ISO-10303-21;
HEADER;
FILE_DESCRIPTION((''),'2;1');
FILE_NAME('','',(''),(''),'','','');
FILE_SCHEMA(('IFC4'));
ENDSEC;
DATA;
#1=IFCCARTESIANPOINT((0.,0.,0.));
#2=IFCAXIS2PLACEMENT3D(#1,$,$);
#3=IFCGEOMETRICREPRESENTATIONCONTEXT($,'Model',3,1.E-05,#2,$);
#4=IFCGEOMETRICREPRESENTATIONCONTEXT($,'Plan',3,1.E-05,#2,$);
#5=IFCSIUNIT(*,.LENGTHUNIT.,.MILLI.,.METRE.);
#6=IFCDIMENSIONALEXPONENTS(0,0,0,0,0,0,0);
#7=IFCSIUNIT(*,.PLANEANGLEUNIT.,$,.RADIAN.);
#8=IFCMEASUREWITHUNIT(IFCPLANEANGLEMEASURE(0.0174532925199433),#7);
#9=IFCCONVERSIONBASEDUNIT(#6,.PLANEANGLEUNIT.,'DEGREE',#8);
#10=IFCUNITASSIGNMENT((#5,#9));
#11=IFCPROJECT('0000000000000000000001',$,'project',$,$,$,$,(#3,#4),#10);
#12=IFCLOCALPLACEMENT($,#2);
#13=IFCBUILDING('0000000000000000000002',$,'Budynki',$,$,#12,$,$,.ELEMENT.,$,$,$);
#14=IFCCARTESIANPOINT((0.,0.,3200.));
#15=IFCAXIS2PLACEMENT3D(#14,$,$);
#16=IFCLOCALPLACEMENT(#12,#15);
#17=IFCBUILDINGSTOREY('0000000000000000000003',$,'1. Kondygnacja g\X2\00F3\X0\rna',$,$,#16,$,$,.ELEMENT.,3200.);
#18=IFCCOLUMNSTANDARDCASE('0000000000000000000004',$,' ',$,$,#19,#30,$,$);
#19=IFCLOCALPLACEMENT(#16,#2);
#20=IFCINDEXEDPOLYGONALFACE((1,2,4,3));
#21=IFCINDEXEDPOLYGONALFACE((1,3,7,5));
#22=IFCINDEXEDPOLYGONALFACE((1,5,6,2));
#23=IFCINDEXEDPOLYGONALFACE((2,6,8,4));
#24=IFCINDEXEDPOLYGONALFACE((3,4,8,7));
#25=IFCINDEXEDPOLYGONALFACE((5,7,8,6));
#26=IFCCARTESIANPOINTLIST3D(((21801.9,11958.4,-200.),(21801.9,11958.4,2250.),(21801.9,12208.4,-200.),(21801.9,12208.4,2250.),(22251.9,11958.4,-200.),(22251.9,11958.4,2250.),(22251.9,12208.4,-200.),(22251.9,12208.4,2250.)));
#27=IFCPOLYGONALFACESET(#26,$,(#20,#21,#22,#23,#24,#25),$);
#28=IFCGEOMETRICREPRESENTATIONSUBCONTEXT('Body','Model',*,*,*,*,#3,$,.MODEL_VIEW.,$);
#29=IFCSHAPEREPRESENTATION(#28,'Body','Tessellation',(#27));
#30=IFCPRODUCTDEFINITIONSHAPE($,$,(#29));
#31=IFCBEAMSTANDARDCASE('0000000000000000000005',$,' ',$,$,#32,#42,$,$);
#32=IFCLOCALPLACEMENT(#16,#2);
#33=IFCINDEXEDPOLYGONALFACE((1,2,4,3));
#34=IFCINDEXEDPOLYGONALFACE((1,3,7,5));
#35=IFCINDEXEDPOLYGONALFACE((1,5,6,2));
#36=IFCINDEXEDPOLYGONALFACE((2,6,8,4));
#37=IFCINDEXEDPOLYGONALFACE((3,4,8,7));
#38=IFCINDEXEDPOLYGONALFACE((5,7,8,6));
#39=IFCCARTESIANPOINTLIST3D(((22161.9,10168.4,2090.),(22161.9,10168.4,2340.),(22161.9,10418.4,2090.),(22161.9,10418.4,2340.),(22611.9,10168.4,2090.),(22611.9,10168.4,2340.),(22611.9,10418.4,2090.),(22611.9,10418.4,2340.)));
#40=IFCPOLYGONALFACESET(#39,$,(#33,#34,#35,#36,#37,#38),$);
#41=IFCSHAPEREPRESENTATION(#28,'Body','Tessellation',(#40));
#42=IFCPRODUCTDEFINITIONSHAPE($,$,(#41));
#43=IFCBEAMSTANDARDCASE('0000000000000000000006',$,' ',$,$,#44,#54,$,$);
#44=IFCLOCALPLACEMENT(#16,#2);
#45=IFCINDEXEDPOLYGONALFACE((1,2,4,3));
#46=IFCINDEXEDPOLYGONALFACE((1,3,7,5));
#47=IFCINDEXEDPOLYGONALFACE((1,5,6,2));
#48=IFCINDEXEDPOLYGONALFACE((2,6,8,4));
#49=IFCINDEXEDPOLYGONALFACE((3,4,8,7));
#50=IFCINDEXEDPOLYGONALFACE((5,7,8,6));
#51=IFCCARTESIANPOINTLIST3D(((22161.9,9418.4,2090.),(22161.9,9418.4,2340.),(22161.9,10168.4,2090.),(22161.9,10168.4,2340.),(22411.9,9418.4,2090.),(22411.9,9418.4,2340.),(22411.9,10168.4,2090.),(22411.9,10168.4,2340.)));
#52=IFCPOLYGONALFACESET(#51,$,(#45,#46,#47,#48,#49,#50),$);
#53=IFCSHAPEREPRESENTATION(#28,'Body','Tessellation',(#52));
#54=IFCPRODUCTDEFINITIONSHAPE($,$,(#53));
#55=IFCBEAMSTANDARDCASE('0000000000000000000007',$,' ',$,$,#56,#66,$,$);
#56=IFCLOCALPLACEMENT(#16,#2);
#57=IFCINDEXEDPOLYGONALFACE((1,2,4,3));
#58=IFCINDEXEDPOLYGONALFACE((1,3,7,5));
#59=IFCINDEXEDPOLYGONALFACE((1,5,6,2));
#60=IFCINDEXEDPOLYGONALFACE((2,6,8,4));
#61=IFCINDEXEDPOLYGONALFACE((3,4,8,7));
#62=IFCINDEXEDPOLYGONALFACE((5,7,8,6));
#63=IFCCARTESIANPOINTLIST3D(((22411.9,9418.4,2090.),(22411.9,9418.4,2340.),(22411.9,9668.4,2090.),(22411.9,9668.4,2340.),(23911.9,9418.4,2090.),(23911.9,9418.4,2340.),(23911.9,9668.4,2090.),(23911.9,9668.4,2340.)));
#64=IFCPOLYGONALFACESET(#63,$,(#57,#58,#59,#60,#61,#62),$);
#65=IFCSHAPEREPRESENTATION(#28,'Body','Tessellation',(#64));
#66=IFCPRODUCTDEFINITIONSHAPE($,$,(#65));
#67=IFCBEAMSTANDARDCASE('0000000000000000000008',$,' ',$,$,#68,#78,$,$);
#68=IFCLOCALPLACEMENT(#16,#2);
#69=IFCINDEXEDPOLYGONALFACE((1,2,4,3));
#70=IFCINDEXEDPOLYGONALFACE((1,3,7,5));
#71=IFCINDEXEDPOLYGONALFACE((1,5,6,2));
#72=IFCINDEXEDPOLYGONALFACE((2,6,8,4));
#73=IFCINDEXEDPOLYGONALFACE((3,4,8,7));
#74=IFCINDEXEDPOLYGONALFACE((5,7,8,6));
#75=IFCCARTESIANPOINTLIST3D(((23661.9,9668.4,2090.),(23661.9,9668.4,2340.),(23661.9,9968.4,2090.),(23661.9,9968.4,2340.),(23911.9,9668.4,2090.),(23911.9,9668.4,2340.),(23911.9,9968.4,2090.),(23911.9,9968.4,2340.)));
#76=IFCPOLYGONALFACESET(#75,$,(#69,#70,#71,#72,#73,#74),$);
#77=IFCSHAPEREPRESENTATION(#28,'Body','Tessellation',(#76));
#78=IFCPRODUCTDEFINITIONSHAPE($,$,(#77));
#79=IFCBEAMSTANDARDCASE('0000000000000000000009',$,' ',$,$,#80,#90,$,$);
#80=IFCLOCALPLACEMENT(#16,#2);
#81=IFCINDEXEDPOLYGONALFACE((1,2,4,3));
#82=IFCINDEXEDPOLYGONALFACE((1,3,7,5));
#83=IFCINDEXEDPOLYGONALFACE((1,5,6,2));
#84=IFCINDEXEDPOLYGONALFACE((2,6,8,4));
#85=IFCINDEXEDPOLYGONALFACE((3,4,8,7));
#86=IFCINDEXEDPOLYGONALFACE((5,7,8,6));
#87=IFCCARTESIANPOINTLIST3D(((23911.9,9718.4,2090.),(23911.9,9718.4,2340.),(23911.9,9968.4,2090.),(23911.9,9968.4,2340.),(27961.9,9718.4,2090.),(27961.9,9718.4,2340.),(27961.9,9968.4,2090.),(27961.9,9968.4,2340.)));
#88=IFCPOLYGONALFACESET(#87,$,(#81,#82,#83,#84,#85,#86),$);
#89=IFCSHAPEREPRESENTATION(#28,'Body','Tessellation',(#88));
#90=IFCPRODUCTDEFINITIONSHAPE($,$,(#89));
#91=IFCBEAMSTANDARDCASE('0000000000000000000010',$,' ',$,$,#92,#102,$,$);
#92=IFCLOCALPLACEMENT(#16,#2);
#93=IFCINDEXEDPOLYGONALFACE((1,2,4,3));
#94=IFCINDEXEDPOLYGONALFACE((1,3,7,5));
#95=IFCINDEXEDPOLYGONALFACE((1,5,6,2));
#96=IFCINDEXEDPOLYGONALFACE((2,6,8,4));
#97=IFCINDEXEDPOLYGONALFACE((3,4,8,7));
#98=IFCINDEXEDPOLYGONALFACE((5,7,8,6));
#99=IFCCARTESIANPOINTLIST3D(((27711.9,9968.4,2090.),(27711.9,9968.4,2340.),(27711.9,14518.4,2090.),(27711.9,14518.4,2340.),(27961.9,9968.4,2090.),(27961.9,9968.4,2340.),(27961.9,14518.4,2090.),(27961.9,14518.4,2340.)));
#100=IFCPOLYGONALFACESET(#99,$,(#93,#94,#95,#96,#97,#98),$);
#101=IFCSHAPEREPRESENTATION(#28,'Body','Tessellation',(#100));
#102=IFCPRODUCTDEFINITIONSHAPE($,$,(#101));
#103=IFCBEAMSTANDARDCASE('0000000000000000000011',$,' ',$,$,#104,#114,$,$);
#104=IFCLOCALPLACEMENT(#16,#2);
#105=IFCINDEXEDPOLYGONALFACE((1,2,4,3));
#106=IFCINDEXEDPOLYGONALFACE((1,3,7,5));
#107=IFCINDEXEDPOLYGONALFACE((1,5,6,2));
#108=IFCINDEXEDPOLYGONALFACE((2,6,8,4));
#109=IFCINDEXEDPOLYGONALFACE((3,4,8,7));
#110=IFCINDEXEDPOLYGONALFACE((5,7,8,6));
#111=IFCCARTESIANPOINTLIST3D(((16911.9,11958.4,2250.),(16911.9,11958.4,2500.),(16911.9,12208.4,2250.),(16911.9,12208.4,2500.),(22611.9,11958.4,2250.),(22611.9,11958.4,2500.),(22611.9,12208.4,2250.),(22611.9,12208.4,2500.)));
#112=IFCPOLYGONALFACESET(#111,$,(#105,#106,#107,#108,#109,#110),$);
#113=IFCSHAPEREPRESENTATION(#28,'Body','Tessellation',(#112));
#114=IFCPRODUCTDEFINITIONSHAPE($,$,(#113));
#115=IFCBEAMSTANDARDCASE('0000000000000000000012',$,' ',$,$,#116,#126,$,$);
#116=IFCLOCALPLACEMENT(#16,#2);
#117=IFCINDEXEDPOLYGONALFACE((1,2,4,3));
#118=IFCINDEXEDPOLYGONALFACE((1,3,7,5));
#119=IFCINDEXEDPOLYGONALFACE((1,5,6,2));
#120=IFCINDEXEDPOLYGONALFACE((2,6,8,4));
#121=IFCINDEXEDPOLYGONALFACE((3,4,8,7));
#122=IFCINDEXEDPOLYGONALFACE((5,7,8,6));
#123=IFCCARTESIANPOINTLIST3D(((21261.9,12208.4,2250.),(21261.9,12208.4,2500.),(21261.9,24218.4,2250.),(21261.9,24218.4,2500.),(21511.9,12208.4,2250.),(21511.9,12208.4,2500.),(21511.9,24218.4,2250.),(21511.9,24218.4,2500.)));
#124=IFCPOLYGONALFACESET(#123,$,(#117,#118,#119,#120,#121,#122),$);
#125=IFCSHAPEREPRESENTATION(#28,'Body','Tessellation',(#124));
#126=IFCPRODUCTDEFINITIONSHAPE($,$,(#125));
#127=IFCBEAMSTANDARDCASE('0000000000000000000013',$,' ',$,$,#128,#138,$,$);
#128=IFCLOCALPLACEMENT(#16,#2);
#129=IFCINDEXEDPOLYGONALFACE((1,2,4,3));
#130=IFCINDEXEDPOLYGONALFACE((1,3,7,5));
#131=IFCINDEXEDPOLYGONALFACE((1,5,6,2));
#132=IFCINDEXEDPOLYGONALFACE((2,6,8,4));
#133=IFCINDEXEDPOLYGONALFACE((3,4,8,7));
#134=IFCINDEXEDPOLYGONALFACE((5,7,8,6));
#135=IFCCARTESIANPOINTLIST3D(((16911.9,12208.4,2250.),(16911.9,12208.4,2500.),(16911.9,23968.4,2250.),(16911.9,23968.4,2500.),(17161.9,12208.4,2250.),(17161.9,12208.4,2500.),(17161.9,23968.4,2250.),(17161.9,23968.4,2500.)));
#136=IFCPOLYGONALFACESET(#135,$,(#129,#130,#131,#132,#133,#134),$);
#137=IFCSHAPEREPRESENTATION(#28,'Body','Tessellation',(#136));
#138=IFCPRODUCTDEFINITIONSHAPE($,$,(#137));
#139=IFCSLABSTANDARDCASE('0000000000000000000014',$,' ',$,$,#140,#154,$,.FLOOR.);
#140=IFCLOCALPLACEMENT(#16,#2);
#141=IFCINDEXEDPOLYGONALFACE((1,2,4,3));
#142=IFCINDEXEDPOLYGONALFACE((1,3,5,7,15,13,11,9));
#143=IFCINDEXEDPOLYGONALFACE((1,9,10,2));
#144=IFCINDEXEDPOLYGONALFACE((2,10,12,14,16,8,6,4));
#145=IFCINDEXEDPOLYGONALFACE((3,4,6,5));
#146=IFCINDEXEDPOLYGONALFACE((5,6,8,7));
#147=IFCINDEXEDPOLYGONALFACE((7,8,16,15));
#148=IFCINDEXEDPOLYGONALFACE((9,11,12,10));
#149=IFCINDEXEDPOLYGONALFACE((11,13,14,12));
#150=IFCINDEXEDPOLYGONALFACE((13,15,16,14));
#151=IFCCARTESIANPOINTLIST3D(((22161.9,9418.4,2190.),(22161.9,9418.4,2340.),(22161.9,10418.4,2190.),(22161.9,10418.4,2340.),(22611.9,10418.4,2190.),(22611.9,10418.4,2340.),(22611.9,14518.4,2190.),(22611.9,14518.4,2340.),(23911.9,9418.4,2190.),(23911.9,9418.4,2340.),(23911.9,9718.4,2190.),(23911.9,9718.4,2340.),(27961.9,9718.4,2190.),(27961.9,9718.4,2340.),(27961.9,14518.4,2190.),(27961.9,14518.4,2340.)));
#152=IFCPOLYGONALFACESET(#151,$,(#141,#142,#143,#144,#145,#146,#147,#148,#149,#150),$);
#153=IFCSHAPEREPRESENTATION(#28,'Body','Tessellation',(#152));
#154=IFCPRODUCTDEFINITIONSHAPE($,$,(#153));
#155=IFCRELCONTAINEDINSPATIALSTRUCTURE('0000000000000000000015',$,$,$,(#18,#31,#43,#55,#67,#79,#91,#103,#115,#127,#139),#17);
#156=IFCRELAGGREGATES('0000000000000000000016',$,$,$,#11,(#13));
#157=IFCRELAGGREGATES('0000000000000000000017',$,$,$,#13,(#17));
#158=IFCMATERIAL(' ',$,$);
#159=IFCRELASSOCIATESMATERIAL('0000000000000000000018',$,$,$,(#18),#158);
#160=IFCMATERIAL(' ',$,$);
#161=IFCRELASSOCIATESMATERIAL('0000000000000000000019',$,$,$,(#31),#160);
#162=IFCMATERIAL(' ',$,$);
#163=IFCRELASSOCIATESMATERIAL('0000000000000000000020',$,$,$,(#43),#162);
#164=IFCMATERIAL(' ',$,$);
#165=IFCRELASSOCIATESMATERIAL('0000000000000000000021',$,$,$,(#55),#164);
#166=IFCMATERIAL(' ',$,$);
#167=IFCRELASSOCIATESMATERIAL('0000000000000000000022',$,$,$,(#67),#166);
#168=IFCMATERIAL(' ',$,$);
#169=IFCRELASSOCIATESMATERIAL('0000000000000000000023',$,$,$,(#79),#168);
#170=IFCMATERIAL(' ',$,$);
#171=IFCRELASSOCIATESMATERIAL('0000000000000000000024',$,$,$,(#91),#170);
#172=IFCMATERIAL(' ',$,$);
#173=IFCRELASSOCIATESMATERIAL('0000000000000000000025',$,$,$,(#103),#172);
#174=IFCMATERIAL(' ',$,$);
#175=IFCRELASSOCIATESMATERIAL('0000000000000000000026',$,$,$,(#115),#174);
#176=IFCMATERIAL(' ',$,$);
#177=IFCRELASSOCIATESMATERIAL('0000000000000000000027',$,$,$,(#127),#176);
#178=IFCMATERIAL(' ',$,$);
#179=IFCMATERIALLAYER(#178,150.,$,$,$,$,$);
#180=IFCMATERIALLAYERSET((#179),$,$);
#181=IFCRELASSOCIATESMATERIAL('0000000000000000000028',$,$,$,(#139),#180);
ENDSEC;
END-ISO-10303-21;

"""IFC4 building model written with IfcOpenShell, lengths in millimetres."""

from ifc_helpers import new_model, entity, si_unit, converted_unit, frame, frame_2d, origin, origin_with_axes, place, context, subcontext, project, spatial, polyline, rectangle, outline, extrude, material, layer, layer_set, layer_usage, material_profile, profile_set, profile_usage, element, save


model = new_model("IFC4")

# Units and contexts
model_context = context("Model", 3, precision=1e-05, world=origin())
plan_context = context("Plan", 3, precision=1e-05, world=origin())
body_context = subcontext(model_context, "Body", "Model", "MODEL_VIEW")
ifc_project = project(units=[si_unit("LENGTHUNIT", "METRE", prefix="MILLI"), converted_unit("PLANEANGLEUNIT", "DEGREE", entity("IfcPlaneAngleMeasure", 0.0174532925199433), si_unit("PLANEANGLEUNIT", "RADIAN"), dimensions=[0, 0, 0, 0, 0, 0, 0])], contexts=[model_context, plan_context])

# Building, storey
building_placement = place(None, origin())
building = spatial("IfcBuilding", under=ifc_project, at=building_placement, Name="Budynki", CompositionType="ELEMENT")
storey_placement = place(building_placement, frame((0.0, 0.0, 3200.0)))
storey = spatial("IfcBuildingStorey", under=building, at=storey_placement, Name="1. Kondygnacja górna", CompositionType="ELEMENT", Elevation=3200.0)

# Column
ifc_material_1 = material(Name=" ")
ifc_material_profile_1 = material_profile(ifc_material_1, rectangle(XDim=450.0, YDim=250.0, at=frame_2d((225.0, 125.0), x_axis=(1.0, 0.0))))
ifc_profile_set_1 = profile_set([ifc_material_profile_1])
ifc_profile_usage_1 = profile_usage(ifc_profile_set_1)
column_placement = place(storey_placement, frame((21801.9, 11958.4, -200.0)))
element("IfcColumnStandardCase", 1, at=column_placement, inside=storey, material=ifc_profile_usage_1, Name=" ", context=body_context, shape_type="SweptSolid", body=[
    extrude(rectangle(XDim=450.0, YDim=250.0, at=frame_2d((225.0, 125.0), x_axis=(1.0, 0.0))), frame((0.0, 0.0, 0.0), z_axis=(0.0, 0.0, 1.0), x_axis=(1.0, 0.0, 0.0)), (0.0, 0.0, 1.0), 2450.0),
])

# Beams
ifc_material_2 = material(Name=" ")
ifc_material_profile_2 = material_profile(ifc_material_2, rectangle(XDim=250.0, YDim=250.0, at=frame_2d((125.0, -125.0), x_axis=(0.0, 1.0))))
ifc_profile_set_2 = profile_set([ifc_material_profile_2])
ifc_profile_usage_2 = profile_usage(ifc_profile_set_2)
beam_1_placement = place(storey_placement, frame((22161.9, 10168.4, 2090.0), z_axis=(0.0, 0.0, 1.0), x_axis=(1.0, 0.0, 0.0)))
element("IfcBeamStandardCase", 2, at=beam_1_placement, inside=storey, material=ifc_profile_usage_2, Name=" ", context=body_context, shape_type="SweptSolid", body=[
    extrude(rectangle(XDim=250.0, YDim=250.0, at=frame_2d((125.0, -125.0), x_axis=(0.0, 1.0))), frame((0.0, 0.0, 0.0), z_axis=(1.0, 0.0, 0.0), x_axis=(0.0, 0.0, 1.0)), (0.0, 0.0, 1.0), 450.0),
])
ifc_material_3 = material(Name=" ")
ifc_material_profile_3 = material_profile(ifc_material_3, rectangle(XDim=250.0, YDim=250.0, at=frame_2d((125.0, -125.0), x_axis=(0.0, 1.0))))
ifc_profile_set_3 = profile_set([ifc_material_profile_3])
ifc_profile_usage_3 = profile_usage(ifc_profile_set_3)
beam_2_placement = place(storey_placement, frame((22161.9, 10168.4, 2090.0), z_axis=(0.0, 0.0, 1.0), x_axis=(0.0, -1.0, 0.0)))
element("IfcBeamStandardCase", 3, at=beam_2_placement, inside=storey, material=ifc_profile_usage_3, Name=" ", context=body_context, shape_type="SweptSolid", body=[
    extrude(rectangle(XDim=250.0, YDim=250.0, at=frame_2d((125.0, -125.0), x_axis=(0.0, 1.0))), frame((0.0, 0.0, 0.0), z_axis=(1.0, 0.0, 0.0), x_axis=(0.0, 0.0, 1.0)), (0.0, 0.0, 1.0), 750.0),
])
ifc_material_4 = material(Name=" ")
ifc_material_profile_4 = material_profile(ifc_material_4, rectangle(XDim=250.0, YDim=250.0, at=frame_2d((125.0, -125.0), x_axis=(0.0, 1.0))))
ifc_profile_set_4 = profile_set([ifc_material_profile_4])
ifc_profile_usage_4 = profile_usage(ifc_profile_set_4)
beam_3_placement = place(storey_placement, frame((22411.9, 9418.4, 2090.0)))
element("IfcBeamStandardCase", 4, at=beam_3_placement, inside=storey, material=ifc_profile_usage_4, Name=" ", context=body_context, shape_type="SweptSolid", body=[
    extrude(rectangle(XDim=250.0, YDim=250.0, at=frame_2d((125.0, -125.0), x_axis=(0.0, 1.0))), frame((0.0, 0.0, 0.0), z_axis=(1.0, 0.0, 0.0), x_axis=(0.0, 0.0, 1.0)), (0.0, 0.0, 1.0), 1500.0),
])
ifc_material_5 = material(Name=" ")
ifc_material_profile_5 = material_profile(ifc_material_5, rectangle(XDim=250.0, YDim=250.0, at=frame_2d((125.0, -125.0), x_axis=(0.0, 1.0))))
ifc_profile_set_5 = profile_set([ifc_material_profile_5])
ifc_profile_usage_5 = profile_usage(ifc_profile_set_5)
beam_4_placement = place(storey_placement, frame((23911.9, 9668.4, 2090.0), z_axis=(0.0, 0.0, 1.0), x_axis=(0.0, 1.0, 0.0)))
element("IfcBeamStandardCase", 5, at=beam_4_placement, inside=storey, material=ifc_profile_usage_5, Name=" ", context=body_context, shape_type="SweptSolid", body=[
    extrude(rectangle(XDim=250.0, YDim=250.0, at=frame_2d((125.0, -125.0), x_axis=(0.0, 1.0))), frame((0.0, 0.0, 0.0), z_axis=(1.0, 0.0, 0.0), x_axis=(0.0, 0.0, 1.0)), (0.0, 0.0, 1.0), 300.0),
])
ifc_material_6 = material(Name=" ")
ifc_material_profile_6 = material_profile(ifc_material_6, rectangle(XDim=250.0, YDim=250.0, at=frame_2d((125.0, -125.0), x_axis=(0.0, 1.0))))
ifc_profile_set_6 = profile_set([ifc_material_profile_6])
ifc_profile_usage_6 = profile_usage(ifc_profile_set_6)
beam_5_placement = place(storey_placement, frame((27961.9, 9968.4, 2090.0), z_axis=(0.0, 0.0, 1.0), x_axis=(-1.0, 0.0, 0.0)))
element("IfcBeamStandardCase", 6, at=beam_5_placement, inside=storey, material=ifc_profile_usage_6, Name=" ", context=body_context, shape_type="SweptSolid", body=[
    extrude(rectangle(XDim=250.0, YDim=250.0, at=frame_2d((125.0, -125.0), x_axis=(0.0, 1.0))), frame((0.0, 0.0, 0.0), z_axis=(1.0, 0.0, 0.0), x_axis=(0.0, 0.0, 1.0)), (0.0, 0.0, 1.0), 4050.0),
])
ifc_material_7 = material(Name=" ")
ifc_material_profile_7 = material_profile(ifc_material_7, rectangle(XDim=250.0, YDim=250.0, at=frame_2d((125.0, -125.0), x_axis=(0.0, 1.0))))
ifc_profile_set_7 = profile_set([ifc_material_profile_7])
ifc_profile_usage_7 = profile_usage(ifc_profile_set_7)
beam_6_placement = place(storey_placement, frame((27961.9, 9968.4, 2090.0), z_axis=(0.0, 0.0, 1.0), x_axis=(0.0, 1.0, 0.0)))
element("IfcBeamStandardCase", 7, at=beam_6_placement, inside=storey, material=ifc_profile_usage_7, Name=" ", context=body_context, shape_type="SweptSolid", body=[
    extrude(rectangle(XDim=250.0, YDim=250.0, at=frame_2d((125.0, -125.0), x_axis=(0.0, 1.0))), frame((0.0, 0.0, 0.0), z_axis=(1.0, 0.0, 0.0), x_axis=(0.0, 0.0, 1.0)), (0.0, 0.0, 1.0), 4550.0),
])
ifc_material_8 = material(Name=" ")
ifc_material_profile_8 = material_profile(ifc_material_8, rectangle(XDim=250.0, YDim=250.0, at=frame_2d((125.0, -125.0), x_axis=(0.0, 1.0))))
ifc_profile_set_8 = profile_set([ifc_material_profile_8])
ifc_profile_usage_8 = profile_usage(ifc_profile_set_8)
beam_7_placement = place(storey_placement, frame((22611.9, 12208.4, 2250.0), z_axis=(0.0, 0.0, 1.0), x_axis=(-1.0, 0.0, 0.0)))
element("IfcBeamStandardCase", 8, at=beam_7_placement, inside=storey, material=ifc_profile_usage_8, Name=" ", context=body_context, shape_type="SweptSolid", body=[
    extrude(rectangle(XDim=250.0, YDim=250.0, at=frame_2d((125.0, -125.0), x_axis=(0.0, 1.0))), frame((0.0, 0.0, 0.0), z_axis=(1.0, 0.0, 0.0), x_axis=(0.0, 0.0, 1.0)), (0.0, 0.0, 1.0), 5700.0),
])
ifc_material_9 = material(Name=" ")
ifc_material_profile_9 = material_profile(ifc_material_9, rectangle(XDim=250.0, YDim=250.0, at=frame_2d((125.0, -125.0), x_axis=(0.0, 1.0))))
ifc_profile_set_9 = profile_set([ifc_material_profile_9])
ifc_profile_usage_9 = profile_usage(ifc_profile_set_9)
beam_8_placement = place(storey_placement, frame((21511.9, 12208.4, 2250.0), z_axis=(0.0, 0.0, 1.0), x_axis=(0.0, 1.0, 0.0)))
element("IfcBeamStandardCase", 9, at=beam_8_placement, inside=storey, material=ifc_profile_usage_9, Name=" ", context=body_context, shape_type="SweptSolid", body=[
    extrude(rectangle(XDim=250.0, YDim=250.0, at=frame_2d((125.0, -125.0), x_axis=(0.0, 1.0))), frame((0.0, 0.0, 0.0), z_axis=(1.0, 0.0, 0.0), x_axis=(0.0, 0.0, 1.0)), (0.0, 0.0, 1.0), 12010.0),
])
ifc_material_10 = material(Name=" ")
ifc_material_profile_10 = material_profile(ifc_material_10, rectangle(XDim=250.0, YDim=250.0, at=frame_2d((125.0, -125.0), x_axis=(0.0, 1.0))))
ifc_profile_set_10 = profile_set([ifc_material_profile_10])
ifc_profile_usage_10 = profile_usage(ifc_profile_set_10)
beam_9_placement = place(storey_placement, frame((17161.9, 12208.4, 2250.0), z_axis=(0.0, 0.0, 1.0), x_axis=(0.0, 1.0, 0.0)))
element("IfcBeamStandardCase", 10, at=beam_9_placement, inside=storey, material=ifc_profile_usage_10, Name=" ", context=body_context, shape_type="SweptSolid", body=[
    extrude(rectangle(XDim=250.0, YDim=250.0, at=frame_2d((125.0, -125.0), x_axis=(0.0, 1.0))), frame((0.0, 0.0, 0.0), z_axis=(1.0, 0.0, 0.0), x_axis=(0.0, 0.0, 1.0)), (0.0, 0.0, 1.0), 11760.0),
])

# Slab
ifc_material_11 = material(Name=" ")
ifc_layer_1 = layer(ifc_material_11, 150.0)
ifc_layer_set_1 = layer_set([ifc_layer_1])
ifc_layer_usage_1 = layer_usage(ifc_layer_set_1, "AXIS3", "POSITIVE", 0.0)
slab_1_placement = place(storey_placement, frame((22161.9, 9418.4, 2190.0)))
element("IfcSlabStandardCase", 11, at=slab_1_placement, inside=storey, material=ifc_layer_usage_1, Name=" ", PredefinedType="FLOOR", context=body_context, shape_type="SweptSolid", body=[
    extrude(outline(polyline([(450.0, 5100.0), (450.0, 1000.0), (0.0, 1000.0), (0.0, 0.0), (1750.0, 0.0), (1750.0, 300.0), (5800.0, 300.0), (5800.0, 5100.0), (450.0, 5100.0)])), origin_with_axes(), (0.0, 0.0, 1.0), 150.0),
])

save(model, "model.ifc")
